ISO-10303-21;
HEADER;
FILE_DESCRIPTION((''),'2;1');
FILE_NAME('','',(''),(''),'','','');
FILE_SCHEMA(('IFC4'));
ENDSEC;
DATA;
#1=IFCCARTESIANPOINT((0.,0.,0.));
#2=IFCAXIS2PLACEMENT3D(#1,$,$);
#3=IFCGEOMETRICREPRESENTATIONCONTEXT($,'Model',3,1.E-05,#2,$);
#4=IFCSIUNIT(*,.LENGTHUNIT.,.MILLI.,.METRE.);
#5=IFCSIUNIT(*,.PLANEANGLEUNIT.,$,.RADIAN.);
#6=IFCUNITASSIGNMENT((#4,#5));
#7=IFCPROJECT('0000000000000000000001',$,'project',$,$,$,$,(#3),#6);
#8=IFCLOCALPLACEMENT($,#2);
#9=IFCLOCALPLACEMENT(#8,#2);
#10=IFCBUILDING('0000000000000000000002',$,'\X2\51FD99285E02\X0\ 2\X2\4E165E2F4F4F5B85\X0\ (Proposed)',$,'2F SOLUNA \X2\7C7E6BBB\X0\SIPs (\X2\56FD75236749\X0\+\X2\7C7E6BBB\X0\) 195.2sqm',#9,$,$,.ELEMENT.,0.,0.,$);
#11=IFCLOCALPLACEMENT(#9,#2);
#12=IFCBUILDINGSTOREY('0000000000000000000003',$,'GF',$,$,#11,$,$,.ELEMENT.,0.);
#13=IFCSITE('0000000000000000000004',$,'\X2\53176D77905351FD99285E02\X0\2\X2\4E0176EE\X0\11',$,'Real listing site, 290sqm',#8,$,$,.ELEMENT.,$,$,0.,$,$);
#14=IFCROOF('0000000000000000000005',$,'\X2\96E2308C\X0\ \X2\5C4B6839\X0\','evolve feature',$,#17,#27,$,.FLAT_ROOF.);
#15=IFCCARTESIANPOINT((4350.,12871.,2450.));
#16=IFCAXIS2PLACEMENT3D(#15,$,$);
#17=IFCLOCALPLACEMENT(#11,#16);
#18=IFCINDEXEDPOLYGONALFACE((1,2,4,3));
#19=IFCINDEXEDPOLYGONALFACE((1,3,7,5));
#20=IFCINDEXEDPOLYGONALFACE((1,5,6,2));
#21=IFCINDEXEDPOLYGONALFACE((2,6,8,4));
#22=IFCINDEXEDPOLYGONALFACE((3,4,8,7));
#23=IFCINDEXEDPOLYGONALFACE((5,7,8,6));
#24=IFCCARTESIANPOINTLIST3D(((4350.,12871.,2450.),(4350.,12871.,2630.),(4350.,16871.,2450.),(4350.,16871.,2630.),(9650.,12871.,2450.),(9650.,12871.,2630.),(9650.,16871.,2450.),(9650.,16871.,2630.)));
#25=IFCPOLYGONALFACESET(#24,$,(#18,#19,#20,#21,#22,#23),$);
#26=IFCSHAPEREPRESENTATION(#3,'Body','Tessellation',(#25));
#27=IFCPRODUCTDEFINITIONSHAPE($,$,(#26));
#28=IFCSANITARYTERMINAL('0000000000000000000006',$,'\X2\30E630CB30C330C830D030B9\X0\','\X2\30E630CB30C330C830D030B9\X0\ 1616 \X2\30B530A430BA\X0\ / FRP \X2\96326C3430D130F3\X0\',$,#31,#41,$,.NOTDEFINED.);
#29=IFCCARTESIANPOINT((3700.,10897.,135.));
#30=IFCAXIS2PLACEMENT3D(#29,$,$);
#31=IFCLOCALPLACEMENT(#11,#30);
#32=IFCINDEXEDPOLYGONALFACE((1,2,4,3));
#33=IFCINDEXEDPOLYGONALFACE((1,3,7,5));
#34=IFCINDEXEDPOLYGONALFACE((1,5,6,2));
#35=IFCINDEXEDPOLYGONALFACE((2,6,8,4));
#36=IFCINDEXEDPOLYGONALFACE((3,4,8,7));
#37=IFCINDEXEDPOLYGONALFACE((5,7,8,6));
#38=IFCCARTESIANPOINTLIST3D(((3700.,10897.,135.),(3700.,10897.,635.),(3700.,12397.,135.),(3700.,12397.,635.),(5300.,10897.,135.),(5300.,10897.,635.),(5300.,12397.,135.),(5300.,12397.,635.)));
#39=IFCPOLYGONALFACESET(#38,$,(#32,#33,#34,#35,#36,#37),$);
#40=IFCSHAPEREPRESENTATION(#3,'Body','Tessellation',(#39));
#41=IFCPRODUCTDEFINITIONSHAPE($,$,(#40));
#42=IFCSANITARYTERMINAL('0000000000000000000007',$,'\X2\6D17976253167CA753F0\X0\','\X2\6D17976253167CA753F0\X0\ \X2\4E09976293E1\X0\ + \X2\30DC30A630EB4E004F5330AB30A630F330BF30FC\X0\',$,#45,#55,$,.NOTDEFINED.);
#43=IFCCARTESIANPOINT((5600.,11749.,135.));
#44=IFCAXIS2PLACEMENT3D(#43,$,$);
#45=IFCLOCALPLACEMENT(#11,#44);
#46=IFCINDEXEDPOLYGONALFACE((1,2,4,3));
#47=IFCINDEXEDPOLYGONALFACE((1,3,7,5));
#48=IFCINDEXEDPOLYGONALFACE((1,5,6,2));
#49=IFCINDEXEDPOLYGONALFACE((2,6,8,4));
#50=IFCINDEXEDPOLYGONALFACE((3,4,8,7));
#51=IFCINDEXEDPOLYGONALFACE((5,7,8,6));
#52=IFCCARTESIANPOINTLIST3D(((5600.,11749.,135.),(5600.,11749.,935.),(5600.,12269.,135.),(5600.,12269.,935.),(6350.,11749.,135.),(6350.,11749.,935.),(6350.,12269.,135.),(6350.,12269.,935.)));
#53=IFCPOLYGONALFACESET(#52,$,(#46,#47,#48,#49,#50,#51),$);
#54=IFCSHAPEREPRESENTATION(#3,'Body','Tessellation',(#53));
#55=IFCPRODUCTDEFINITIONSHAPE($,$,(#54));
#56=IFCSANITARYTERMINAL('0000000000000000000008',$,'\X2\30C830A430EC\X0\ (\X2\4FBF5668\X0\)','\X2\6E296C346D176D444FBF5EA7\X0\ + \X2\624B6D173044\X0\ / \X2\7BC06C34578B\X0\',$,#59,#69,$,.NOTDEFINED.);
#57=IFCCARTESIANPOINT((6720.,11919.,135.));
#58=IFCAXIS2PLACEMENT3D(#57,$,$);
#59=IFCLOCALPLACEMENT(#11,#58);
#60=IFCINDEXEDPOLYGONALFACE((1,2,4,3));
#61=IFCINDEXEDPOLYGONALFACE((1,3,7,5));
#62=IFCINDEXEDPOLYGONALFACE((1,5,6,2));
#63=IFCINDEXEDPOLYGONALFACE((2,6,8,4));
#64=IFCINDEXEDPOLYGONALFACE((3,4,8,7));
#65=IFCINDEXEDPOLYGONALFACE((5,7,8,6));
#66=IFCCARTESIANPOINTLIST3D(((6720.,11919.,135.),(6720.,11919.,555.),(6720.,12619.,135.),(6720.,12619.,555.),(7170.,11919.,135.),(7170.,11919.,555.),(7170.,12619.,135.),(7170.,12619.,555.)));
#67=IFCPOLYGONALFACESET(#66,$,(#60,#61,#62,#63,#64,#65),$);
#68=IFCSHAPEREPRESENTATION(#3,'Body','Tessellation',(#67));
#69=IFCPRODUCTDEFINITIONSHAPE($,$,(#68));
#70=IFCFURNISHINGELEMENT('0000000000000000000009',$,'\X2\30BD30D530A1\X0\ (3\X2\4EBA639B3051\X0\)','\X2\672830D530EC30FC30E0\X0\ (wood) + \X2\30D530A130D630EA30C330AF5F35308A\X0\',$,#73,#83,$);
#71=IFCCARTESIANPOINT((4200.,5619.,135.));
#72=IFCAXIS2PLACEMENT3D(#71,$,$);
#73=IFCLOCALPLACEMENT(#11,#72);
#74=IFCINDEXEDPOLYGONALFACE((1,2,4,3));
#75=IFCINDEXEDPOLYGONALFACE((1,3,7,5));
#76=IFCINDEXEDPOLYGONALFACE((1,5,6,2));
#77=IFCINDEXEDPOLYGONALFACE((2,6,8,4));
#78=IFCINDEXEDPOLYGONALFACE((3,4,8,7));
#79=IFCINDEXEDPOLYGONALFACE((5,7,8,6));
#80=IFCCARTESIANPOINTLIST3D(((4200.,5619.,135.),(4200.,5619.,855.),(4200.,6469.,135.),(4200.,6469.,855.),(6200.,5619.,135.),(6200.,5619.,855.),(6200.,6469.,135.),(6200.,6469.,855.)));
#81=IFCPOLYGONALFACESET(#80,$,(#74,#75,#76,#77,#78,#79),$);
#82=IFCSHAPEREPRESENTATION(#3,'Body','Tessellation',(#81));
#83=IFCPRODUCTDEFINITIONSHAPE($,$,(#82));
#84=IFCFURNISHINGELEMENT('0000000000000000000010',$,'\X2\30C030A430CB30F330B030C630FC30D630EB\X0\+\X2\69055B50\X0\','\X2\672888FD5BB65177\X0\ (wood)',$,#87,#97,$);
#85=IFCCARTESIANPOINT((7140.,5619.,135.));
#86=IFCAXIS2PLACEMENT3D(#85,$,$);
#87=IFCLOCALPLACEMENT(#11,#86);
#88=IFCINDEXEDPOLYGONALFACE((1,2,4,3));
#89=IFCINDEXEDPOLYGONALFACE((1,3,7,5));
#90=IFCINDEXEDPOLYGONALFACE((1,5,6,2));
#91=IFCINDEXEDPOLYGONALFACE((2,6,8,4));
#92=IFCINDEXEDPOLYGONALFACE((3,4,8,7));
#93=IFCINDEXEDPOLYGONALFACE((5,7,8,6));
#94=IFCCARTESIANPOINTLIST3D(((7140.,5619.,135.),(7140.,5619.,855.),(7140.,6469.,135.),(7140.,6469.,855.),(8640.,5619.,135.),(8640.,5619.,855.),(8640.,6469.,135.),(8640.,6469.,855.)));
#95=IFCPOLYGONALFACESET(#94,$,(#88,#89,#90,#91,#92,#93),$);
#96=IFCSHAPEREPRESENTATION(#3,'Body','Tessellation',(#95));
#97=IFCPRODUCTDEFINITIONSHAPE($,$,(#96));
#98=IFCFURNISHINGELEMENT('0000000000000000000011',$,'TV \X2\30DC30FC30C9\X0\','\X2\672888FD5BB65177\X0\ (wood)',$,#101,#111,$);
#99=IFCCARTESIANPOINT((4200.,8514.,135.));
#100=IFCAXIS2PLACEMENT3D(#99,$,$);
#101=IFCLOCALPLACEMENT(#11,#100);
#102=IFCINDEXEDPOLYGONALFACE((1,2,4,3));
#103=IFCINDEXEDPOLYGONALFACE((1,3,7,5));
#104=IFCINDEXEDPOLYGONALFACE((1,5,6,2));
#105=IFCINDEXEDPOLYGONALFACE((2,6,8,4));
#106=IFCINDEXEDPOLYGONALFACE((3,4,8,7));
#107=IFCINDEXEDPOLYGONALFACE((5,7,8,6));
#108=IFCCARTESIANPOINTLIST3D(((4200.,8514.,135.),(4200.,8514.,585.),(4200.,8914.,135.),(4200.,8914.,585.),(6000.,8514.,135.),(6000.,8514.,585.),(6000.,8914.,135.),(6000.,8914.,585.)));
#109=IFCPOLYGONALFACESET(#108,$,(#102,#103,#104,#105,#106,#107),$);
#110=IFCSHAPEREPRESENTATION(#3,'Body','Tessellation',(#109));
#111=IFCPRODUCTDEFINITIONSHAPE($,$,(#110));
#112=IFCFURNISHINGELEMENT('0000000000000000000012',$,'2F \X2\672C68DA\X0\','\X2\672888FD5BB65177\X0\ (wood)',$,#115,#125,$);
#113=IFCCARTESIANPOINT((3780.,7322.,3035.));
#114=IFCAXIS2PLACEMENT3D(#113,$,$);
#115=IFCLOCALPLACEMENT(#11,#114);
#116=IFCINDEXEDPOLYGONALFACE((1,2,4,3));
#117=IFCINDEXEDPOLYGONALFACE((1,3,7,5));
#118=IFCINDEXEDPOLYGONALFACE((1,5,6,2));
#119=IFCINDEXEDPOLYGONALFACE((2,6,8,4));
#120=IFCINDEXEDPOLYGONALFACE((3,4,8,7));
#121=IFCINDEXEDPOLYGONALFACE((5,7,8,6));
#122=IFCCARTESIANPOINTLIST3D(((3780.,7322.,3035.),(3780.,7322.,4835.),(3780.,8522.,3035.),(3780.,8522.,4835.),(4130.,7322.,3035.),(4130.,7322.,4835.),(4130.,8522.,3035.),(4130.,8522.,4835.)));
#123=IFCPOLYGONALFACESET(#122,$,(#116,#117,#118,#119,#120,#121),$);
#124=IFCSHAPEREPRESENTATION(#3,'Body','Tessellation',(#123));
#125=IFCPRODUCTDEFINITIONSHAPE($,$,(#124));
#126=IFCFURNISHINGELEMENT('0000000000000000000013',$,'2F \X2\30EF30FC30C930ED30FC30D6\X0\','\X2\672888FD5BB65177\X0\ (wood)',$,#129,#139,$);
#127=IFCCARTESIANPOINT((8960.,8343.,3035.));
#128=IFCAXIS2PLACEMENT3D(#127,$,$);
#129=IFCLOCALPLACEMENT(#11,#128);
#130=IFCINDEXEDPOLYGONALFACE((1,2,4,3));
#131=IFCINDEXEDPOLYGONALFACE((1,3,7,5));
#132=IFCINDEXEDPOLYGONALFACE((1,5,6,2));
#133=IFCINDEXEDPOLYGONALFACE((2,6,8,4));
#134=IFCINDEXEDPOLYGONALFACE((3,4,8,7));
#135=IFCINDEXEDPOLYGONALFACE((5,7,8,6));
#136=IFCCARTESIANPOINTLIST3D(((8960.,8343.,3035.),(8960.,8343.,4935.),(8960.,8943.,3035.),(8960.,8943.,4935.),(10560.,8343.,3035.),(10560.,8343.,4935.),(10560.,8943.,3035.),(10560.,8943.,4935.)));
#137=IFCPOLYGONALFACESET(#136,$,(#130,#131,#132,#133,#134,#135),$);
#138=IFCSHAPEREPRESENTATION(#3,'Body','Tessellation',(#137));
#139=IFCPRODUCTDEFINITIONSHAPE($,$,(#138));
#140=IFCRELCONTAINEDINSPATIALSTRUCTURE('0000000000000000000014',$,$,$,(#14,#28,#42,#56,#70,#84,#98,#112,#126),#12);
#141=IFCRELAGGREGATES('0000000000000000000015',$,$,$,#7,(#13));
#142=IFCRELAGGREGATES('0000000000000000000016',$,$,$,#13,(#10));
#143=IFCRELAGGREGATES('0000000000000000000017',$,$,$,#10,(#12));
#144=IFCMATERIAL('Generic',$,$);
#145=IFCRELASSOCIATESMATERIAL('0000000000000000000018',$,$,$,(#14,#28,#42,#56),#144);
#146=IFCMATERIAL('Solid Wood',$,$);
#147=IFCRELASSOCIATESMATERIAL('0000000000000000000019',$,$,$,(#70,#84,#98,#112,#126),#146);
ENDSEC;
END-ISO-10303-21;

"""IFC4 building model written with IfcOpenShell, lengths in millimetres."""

from ifc_helpers import new_model, si_unit, frame, frame_2d, origin, place, context, project, spatial, rectangle, extrude, material, element, save


model = new_model("IFC4")

# Units and contexts
model_context = context("Model", 3, precision=1e-05, world=origin())
ifc_project = project(units=[si_unit("LENGTHUNIT", "METRE", prefix="MILLI"), si_unit("PLANEANGLEUNIT", "RADIAN")], contexts=[model_context])

# Site, building, storey
site_placement = place(None, origin())
site = spatial("IfcSite", under=ifc_project, at=site_placement, Name="北海道函館市2丁目11", ObjectType="Real listing site, 290sqm", CompositionType="ELEMENT", RefElevation=0.0)
building_placement = place(site_placement, origin())
building = spatial("IfcBuilding", under=site, at=building_placement, Name="函館市 2世帯住宅 (Proposed)", ObjectType="2F SOLUNA 籾殻SIPs (国産杉+籾殻) 195.2sqm", CompositionType="ELEMENT", ElevationOfRefHeight=0.0, ElevationOfTerrain=0.0)
storey_placement = place(building_placement, origin())
storey = spatial("IfcBuildingStorey", under=building, at=storey_placement, Name="GF", CompositionType="ELEMENT", Elevation=0.0)

# Shared definitions
ifc_material_1 = material(Name="Generic")

# Shared definitions
ifc_material_2 = material(Name="Solid Wood")

# Roof
roof_placement = place(storey_placement, frame((4350.0, 12871.0, 2450.0)))
element("IfcRoof", 1, at=roof_placement, inside=storey, material=ifc_material_1, Name="離れ 屋根", Description="evolve feature", PredefinedType="FLAT_ROOF", context=model_context, shape_type="SweptSolid", body=[
    extrude(rectangle(XDim=5300.0, YDim=4000.0, at=frame_2d((2650.0, 2000.0))), frame((4350.0, 12871.0, 2450.0)), (0.0, 0.0, 1.0), 180.0),
])

# Sanitary terminals
sanitary_terminal_1_placement = place(storey_placement, frame((3700.0, 10897.0, 135.0)))
element("IfcSanitaryTerminal", 2, at=sanitary_terminal_1_placement, inside=storey, material=ifc_material_1, Name="ユニットバス", Description="ユニットバス 1616 サイズ / FRP 防水パン", PredefinedType="NOTDEFINED", context=model_context, shape_type="SweptSolid", body=[
    extrude(rectangle(XDim=1600.0, YDim=1500.0, at=frame_2d((800.0, 750.0))), frame((3700.0, 10897.0, 135.0)), (0.0, 0.0, 1.0), 500.0),
])
sanitary_terminal_2_placement = place(storey_placement, frame((5600.0, 11749.0, 135.0)))
element("IfcSanitaryTerminal", 3, at=sanitary_terminal_2_placement, inside=storey, material=ifc_material_1, Name="洗面化粧台", Description="洗面化粧台 三面鏡 + ボウル一体カウンター", PredefinedType="NOTDEFINED", context=model_context, shape_type="SweptSolid", body=[
    extrude(rectangle(XDim=750.0, YDim=520.0, at=frame_2d((375.0, 260.0))), frame((5600.0, 11749.0, 135.0)), (0.0, 0.0, 1.0), 800.0),
])
sanitary_terminal_3_placement = place(storey_placement, frame((6720.0, 11919.0, 135.0)))
element("IfcSanitaryTerminal", 4, at=sanitary_terminal_3_placement, inside=storey, material=ifc_material_1, Name="トイレ (便器)", Description="温水洗浄便座 + 手洗い / 節水型", PredefinedType="NOTDEFINED", context=model_context, shape_type="SweptSolid", body=[
    extrude(rectangle(XDim=450.0, YDim=700.0, at=frame_2d((225.0, 350.0))), frame((6720.0, 11919.0, 135.0)), (0.0, 0.0, 1.0), 420.0),
])

# Furnishing elements
furnishing_1_placement = place(storey_placement, frame((4200.0, 5619.0, 135.0)))
element("IfcFurnishingElement", 5, at=furnishing_1_placement, inside=storey, material=ifc_material_2, Name="ソファ (3人掛け)", Description="木フレーム (wood) + ファブリック張り", context=model_context, shape_type="SweptSolid", body=[
    extrude(rectangle(XDim=2000.0, YDim=850.0, at=frame_2d((1000.0, 425.0))), frame((4200.0, 5619.0, 135.0)), (0.0, 0.0, 1.0), 720.0),
])
furnishing_2_placement = place(storey_placement, frame((7140.0, 5619.0, 135.0)))
element("IfcFurnishingElement", 6, at=furnishing_2_placement, inside=storey, material=ifc_material_2, Name="ダイニングテーブル+椅子", Description="木製家具 (wood)", context=model_context, shape_type="SweptSolid", body=[
    extrude(rectangle(XDim=1500.0, YDim=850.0, at=frame_2d((750.0, 425.0))), frame((7140.0, 5619.0, 135.0)), (0.0, 0.0, 1.0), 720.0),
])
furnishing_3_placement = place(storey_placement, frame((4200.0, 8514.0, 135.0)))
element("IfcFurnishingElement", 7, at=furnishing_3_placement, inside=storey, material=ifc_material_2, Name="TV ボード", Description="木製家具 (wood)", context=model_context, shape_type="SweptSolid", body=[
    extrude(rectangle(XDim=1800.0, YDim=400.0, at=frame_2d((900.0, 200.0))), frame((4200.0, 8514.0, 135.0)), (0.0, 0.0, 1.0), 450.0),
])
furnishing_4_placement = place(storey_placement, frame((3780.0, 7322.0, 3035.0)))
element("IfcFurnishingElement", 8, at=furnishing_4_placement, inside=storey, material=ifc_material_2, Name="2F 本棚", Description="木製家具 (wood)", context=model_context, shape_type="SweptSolid", body=[
    extrude(rectangle(XDim=350.0, YDim=1200.0, at=frame_2d((175.0, 600.0))), frame((3780.0, 7322.0, 3035.0)), (0.0, 0.0, 1.0), 1800.0),
])
furnishing_5_placement = place(storey_placement, frame((8960.0, 8343.0, 3035.0)))
element("IfcFurnishingElement", 9, at=furnishing_5_placement, inside=storey, material=ifc_material_2, Name="2F ワードローブ", Description="木製家具 (wood)", context=model_context, shape_type="SweptSolid", body=[
    extrude(rectangle(XDim=1600.0, YDim=600.0, at=frame_2d((800.0, 300.0))), frame((8960.0, 8343.0, 3035.0)), (0.0, 0.0, 1.0), 1900.0),
])

save(model, "model.ifc")
